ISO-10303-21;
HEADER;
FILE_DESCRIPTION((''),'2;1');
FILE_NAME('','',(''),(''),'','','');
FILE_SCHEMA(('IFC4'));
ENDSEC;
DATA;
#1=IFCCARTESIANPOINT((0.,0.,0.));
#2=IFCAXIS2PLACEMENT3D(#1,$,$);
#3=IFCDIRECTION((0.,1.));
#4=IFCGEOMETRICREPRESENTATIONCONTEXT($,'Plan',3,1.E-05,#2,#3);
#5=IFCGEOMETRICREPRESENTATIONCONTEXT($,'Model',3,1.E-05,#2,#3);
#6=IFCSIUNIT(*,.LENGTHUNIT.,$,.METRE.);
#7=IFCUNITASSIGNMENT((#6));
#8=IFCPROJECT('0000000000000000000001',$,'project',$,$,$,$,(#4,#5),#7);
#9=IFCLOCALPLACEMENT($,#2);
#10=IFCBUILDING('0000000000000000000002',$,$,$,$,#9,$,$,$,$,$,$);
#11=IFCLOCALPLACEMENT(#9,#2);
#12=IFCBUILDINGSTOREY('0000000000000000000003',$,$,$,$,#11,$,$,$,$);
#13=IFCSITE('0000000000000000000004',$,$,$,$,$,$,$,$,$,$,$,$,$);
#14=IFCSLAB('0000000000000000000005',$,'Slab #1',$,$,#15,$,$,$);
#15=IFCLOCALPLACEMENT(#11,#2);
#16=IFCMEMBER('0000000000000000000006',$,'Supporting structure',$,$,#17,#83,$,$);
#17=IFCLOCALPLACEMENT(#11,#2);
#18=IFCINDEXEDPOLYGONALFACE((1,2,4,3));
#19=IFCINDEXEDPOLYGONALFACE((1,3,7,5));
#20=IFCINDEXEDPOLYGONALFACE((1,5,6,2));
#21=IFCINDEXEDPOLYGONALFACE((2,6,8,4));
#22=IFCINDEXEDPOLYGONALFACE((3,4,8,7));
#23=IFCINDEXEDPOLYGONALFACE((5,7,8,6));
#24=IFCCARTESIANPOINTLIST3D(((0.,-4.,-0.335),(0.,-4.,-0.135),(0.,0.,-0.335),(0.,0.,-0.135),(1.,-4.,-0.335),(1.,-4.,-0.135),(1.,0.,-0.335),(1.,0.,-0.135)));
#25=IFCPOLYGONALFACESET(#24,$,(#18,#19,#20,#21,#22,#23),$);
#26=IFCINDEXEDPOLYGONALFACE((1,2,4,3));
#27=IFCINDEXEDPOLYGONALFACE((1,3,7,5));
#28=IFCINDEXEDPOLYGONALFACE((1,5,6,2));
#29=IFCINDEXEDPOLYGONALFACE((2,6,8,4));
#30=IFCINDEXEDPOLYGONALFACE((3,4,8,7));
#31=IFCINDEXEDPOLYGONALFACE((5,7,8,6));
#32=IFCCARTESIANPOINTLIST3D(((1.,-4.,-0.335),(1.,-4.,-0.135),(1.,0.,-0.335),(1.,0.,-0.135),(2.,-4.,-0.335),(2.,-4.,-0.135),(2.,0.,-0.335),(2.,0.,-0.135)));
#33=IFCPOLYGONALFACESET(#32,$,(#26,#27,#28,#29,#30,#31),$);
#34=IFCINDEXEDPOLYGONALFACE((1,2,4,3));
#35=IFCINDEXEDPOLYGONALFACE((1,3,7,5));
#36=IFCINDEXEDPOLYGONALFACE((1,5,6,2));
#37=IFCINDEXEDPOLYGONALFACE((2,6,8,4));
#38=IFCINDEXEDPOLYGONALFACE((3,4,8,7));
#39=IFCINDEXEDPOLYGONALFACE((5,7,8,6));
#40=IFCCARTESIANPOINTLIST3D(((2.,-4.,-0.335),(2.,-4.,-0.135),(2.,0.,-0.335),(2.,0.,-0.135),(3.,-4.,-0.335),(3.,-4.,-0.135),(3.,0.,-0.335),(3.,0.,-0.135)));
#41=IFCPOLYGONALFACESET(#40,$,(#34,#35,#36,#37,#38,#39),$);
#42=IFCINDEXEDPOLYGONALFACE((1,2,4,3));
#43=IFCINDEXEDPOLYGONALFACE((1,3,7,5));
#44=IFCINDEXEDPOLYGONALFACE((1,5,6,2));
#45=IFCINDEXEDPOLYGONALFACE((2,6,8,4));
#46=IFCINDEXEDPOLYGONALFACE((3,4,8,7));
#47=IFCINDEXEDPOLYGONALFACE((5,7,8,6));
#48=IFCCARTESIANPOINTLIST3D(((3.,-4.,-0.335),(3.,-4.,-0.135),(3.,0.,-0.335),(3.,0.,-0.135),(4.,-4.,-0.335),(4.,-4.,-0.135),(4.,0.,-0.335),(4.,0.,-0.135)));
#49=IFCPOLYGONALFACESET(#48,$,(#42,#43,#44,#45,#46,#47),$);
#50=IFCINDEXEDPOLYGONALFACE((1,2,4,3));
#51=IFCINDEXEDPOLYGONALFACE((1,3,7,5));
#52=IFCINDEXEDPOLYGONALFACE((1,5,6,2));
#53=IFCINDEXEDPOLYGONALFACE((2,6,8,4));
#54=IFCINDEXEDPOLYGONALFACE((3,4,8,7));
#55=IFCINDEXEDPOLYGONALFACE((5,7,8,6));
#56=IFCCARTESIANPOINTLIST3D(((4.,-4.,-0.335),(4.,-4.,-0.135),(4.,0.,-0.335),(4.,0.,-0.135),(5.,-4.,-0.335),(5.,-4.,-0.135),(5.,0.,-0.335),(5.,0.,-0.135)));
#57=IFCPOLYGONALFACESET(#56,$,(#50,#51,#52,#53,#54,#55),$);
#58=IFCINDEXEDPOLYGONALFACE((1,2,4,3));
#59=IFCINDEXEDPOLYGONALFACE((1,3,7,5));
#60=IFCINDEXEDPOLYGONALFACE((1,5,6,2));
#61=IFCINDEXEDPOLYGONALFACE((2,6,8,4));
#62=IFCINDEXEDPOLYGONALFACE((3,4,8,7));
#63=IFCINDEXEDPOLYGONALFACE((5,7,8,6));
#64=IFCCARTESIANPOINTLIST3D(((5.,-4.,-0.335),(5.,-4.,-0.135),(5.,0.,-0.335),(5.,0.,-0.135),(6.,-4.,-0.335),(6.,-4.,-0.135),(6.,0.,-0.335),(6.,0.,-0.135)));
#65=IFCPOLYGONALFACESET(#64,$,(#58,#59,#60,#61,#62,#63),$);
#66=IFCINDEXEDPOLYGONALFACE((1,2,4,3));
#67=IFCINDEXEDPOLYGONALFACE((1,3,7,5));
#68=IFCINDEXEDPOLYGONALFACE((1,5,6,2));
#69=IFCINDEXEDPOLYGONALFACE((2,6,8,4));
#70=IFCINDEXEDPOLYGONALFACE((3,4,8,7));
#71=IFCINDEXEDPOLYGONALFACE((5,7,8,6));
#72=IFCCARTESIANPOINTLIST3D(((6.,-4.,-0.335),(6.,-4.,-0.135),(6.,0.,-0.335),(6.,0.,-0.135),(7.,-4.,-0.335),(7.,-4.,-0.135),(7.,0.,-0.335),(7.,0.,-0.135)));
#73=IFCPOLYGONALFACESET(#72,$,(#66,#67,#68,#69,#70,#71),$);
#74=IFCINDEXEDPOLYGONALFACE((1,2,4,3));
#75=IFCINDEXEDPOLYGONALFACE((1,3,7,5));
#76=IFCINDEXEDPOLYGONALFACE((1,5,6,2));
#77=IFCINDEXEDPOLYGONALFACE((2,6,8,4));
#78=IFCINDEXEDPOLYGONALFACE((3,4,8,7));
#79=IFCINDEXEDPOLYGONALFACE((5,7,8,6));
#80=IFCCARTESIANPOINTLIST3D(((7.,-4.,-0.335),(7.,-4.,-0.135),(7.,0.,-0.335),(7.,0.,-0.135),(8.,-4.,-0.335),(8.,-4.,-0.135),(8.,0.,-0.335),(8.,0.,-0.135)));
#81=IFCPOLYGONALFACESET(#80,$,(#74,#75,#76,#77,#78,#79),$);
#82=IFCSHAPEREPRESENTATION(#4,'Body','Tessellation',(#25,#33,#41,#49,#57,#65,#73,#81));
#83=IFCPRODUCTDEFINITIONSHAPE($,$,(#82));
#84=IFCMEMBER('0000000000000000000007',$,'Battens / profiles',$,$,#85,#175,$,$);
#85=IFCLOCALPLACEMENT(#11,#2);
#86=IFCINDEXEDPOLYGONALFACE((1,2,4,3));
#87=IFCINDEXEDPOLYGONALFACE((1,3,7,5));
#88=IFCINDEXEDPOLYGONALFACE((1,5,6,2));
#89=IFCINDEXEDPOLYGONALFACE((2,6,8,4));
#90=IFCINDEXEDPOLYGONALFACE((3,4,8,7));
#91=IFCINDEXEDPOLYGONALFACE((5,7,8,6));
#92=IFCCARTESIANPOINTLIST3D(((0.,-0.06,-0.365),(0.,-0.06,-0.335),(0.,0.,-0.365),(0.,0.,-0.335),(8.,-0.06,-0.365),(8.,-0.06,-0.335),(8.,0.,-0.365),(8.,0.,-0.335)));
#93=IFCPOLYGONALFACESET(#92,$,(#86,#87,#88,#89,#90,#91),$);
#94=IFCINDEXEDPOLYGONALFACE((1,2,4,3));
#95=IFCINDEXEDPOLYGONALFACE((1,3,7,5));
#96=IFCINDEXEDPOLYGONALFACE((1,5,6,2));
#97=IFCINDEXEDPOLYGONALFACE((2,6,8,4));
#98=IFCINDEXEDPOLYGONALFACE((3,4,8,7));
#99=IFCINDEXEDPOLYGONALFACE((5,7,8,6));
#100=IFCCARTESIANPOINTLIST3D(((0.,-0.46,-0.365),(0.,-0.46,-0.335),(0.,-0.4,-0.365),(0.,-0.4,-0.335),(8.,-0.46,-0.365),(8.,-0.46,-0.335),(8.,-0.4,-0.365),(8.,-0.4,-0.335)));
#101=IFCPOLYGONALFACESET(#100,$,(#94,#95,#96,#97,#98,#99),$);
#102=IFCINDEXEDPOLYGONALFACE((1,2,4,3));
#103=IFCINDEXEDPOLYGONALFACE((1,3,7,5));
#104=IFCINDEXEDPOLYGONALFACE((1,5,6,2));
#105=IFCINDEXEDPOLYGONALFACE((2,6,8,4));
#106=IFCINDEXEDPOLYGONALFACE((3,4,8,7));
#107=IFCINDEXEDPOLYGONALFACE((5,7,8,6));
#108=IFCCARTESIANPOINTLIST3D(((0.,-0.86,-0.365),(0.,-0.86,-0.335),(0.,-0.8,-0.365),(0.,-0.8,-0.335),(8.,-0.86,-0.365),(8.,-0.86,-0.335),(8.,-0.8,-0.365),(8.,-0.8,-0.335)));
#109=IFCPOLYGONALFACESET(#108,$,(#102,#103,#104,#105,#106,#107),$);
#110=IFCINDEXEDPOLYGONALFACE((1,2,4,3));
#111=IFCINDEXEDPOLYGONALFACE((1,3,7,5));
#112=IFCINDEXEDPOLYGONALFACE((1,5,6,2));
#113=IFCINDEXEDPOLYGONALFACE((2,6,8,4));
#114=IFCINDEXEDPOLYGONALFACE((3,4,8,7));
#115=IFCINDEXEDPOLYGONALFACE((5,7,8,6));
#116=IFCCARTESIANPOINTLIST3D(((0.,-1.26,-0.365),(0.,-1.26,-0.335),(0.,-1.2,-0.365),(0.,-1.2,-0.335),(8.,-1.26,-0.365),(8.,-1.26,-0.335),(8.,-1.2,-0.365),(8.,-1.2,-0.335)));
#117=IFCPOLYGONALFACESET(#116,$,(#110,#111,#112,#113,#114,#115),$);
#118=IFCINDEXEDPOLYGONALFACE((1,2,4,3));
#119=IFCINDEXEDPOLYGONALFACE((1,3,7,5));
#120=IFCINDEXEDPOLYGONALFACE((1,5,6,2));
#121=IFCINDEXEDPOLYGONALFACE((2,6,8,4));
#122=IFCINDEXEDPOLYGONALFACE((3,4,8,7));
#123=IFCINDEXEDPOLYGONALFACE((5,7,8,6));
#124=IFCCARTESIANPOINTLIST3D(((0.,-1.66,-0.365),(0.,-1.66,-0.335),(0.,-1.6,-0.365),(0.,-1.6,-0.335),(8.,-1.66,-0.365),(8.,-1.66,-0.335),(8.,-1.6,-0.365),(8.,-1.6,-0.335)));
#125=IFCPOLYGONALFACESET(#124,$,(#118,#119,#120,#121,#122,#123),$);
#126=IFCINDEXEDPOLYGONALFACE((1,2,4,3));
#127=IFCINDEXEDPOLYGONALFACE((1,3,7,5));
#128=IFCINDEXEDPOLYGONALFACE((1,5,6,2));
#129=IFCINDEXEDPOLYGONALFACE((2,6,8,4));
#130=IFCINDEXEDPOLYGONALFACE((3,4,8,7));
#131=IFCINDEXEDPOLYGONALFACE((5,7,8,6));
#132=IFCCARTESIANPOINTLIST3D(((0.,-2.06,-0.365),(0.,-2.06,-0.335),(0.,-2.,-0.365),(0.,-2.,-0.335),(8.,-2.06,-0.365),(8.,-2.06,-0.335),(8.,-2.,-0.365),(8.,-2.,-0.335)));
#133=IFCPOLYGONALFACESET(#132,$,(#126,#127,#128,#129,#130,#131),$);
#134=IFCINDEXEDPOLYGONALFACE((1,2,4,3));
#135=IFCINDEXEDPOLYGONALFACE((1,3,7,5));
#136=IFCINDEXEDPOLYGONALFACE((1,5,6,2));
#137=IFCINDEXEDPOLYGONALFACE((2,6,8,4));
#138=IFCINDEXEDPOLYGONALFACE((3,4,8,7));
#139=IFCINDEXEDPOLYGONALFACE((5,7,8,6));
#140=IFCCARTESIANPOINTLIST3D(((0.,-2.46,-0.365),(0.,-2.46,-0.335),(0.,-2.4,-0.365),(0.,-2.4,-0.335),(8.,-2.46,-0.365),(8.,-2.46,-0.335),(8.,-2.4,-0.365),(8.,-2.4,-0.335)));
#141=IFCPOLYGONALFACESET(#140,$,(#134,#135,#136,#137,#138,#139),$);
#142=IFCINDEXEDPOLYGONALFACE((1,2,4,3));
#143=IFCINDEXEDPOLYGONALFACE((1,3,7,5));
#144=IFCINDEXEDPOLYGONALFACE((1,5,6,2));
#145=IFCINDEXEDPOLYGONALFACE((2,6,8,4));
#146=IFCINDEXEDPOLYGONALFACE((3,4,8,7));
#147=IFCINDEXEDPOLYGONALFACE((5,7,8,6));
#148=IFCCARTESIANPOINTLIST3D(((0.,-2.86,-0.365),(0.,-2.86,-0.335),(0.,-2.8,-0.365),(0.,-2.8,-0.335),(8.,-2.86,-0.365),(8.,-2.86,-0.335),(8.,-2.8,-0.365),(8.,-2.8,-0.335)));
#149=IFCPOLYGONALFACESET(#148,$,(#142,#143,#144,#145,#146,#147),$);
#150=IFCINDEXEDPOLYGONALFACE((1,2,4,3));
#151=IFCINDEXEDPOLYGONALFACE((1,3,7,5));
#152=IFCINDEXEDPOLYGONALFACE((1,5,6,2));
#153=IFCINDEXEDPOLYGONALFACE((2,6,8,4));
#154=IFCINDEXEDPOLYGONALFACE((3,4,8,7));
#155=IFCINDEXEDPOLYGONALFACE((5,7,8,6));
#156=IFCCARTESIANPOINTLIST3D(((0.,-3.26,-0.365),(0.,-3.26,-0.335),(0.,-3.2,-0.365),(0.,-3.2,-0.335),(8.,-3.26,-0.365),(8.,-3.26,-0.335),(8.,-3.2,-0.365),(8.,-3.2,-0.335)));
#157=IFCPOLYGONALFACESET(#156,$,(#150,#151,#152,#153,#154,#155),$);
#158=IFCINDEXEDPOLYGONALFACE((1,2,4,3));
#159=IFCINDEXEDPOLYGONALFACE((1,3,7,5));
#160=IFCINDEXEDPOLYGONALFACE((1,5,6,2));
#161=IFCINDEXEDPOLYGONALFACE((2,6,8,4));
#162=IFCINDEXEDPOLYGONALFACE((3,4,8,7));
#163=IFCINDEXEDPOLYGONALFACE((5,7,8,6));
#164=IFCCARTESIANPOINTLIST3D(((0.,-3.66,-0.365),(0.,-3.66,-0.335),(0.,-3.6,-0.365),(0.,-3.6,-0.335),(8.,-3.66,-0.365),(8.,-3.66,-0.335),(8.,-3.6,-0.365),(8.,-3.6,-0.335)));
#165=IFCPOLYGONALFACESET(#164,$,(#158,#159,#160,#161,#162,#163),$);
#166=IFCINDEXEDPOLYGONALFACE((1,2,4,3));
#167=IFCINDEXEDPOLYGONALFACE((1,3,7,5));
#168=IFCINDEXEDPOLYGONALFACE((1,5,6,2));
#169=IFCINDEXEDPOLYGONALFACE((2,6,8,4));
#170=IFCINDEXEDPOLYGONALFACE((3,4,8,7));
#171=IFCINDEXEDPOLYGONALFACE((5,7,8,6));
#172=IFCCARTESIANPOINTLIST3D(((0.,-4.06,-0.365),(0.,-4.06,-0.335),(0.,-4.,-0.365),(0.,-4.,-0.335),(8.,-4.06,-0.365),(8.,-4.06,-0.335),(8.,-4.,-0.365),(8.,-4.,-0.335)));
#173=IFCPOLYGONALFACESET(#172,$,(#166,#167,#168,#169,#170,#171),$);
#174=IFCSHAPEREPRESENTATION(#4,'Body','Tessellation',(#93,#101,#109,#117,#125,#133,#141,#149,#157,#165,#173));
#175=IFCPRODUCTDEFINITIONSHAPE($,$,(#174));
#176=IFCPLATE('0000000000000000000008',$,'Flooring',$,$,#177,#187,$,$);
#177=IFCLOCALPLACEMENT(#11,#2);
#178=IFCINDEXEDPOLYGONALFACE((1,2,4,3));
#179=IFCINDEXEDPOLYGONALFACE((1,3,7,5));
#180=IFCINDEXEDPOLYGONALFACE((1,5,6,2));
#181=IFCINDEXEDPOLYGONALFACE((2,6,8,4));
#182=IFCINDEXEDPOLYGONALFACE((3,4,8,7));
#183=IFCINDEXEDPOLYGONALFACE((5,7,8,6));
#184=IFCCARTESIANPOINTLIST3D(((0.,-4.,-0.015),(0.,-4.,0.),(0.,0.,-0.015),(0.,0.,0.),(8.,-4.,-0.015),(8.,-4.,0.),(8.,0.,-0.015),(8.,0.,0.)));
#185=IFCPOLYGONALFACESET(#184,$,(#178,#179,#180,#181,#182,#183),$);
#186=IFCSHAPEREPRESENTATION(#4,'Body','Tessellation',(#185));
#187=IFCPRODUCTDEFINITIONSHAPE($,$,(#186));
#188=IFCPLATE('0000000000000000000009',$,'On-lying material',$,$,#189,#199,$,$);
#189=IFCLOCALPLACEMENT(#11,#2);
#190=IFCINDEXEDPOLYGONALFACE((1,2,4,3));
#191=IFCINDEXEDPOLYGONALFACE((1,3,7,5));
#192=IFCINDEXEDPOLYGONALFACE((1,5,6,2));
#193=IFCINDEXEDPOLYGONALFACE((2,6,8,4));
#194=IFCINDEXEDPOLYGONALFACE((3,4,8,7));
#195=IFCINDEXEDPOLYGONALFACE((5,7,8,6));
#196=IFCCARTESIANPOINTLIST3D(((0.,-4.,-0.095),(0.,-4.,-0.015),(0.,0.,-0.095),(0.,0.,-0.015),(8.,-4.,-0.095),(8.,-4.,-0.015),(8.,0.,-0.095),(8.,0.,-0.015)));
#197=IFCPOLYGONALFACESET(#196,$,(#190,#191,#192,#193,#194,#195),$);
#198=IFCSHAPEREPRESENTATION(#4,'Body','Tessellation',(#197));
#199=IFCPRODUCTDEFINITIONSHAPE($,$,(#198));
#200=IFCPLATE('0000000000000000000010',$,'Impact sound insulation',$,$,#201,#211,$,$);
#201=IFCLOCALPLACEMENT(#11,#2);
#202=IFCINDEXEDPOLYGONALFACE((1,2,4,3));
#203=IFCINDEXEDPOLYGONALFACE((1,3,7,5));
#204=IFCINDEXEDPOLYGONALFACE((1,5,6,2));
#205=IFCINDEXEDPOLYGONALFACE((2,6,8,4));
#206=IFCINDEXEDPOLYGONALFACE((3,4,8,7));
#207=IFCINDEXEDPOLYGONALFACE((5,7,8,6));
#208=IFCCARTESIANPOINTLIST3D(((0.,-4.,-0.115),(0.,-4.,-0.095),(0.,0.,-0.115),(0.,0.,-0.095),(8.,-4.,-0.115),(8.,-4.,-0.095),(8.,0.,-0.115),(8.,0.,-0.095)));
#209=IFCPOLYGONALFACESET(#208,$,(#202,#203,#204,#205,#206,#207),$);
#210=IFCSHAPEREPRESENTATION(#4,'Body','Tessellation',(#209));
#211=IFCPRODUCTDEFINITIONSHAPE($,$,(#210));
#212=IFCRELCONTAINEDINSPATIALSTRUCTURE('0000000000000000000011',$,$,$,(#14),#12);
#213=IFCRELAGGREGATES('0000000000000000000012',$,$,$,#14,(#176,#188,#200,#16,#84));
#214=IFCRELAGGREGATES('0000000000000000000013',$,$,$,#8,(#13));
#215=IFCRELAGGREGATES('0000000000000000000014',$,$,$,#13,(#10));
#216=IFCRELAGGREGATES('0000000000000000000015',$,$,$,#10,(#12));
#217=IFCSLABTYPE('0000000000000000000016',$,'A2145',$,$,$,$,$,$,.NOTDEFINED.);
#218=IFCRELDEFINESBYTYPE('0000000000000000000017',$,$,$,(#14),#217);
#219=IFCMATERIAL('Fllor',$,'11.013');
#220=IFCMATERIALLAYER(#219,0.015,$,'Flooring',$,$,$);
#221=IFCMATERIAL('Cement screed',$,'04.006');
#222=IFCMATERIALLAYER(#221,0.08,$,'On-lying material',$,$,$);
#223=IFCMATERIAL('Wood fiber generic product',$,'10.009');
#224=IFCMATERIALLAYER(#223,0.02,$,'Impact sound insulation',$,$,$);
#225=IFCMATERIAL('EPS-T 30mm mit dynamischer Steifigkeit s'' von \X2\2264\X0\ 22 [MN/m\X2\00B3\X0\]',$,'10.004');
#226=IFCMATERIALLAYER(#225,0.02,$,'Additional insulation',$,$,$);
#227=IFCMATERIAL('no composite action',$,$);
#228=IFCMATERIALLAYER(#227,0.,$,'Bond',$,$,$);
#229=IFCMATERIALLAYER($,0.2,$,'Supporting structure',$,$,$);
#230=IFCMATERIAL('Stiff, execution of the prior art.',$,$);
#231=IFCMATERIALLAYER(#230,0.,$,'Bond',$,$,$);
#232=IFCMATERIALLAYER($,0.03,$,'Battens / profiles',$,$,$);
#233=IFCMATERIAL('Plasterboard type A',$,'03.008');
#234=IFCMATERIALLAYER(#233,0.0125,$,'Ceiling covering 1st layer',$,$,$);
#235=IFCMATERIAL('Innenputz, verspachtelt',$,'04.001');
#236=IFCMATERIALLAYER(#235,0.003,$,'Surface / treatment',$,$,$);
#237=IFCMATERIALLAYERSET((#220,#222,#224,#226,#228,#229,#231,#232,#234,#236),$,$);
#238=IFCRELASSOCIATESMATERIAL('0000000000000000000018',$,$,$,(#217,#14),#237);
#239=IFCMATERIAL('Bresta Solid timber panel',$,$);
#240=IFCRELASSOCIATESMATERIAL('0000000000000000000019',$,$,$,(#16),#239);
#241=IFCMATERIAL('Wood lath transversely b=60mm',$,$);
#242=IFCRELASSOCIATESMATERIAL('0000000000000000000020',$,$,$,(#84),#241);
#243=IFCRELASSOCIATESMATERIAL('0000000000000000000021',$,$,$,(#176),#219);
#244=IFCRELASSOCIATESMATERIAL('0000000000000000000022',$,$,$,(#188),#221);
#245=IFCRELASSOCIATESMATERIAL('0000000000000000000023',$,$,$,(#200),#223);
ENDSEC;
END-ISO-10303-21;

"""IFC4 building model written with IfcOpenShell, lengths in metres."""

from ifc_helpers import new_model, si_unit, direction, frame, frame_2d, origin, origin_with_axes, place, context, project, spatial, rectangle, extrude, material, layer, layer_set, type_object, element, aggregate, save


model = new_model("IFC4")

# Units and contexts
plan_context = context("Plan", 3, precision=1e-05, world=origin(), true_north=direction((0.0, 1.0)))
model_context = context("Model", 3, precision=1e-05, world=origin(), true_north=direction((0.0, 1.0)))
ifc_project = project(units=[si_unit("LENGTHUNIT", "METRE")], contexts=[plan_context, model_context])

# Site, building, storey
site = spatial("IfcSite", under=ifc_project)
building_placement = place(None, origin())
building = spatial("IfcBuilding", under=site, at=building_placement)
storey_placement = place(building_placement, origin())
storey = spatial("IfcBuildingStorey", under=building, at=storey_placement)

# Slab, members, plates
ifc_material_1 = material(Name="Fllor", Category="11.013")
ifc_layer_1 = layer(ifc_material_1, 0.015, Name="Flooring")
ifc_material_2 = material(Name="Cement screed", Category="04.006")
ifc_layer_2 = layer(ifc_material_2, 0.08, Name="On-lying material")
ifc_material_3 = material(Name="Wood fiber generic product", Category="10.009")
ifc_layer_3 = layer(ifc_material_3, 0.02, Name="Impact sound insulation")
ifc_material_4 = material(Name="EPS-T 30mm mit dynamischer Steifigkeit s' von ≤ 22 [MN/m³]", Category="10.004")
ifc_layer_4 = layer(ifc_material_4, 0.02, Name="Additional insulation")
ifc_material_5 = material(Name="no composite action")
ifc_layer_5 = layer(ifc_material_5, 0.0, Name="Bond")
ifc_layer_6 = layer(None, 0.2, Name="Supporting structure")
ifc_material_6 = material(Name="Stiff, execution of the prior art.")
ifc_layer_7 = layer(ifc_material_6, 0.0, Name="Bond")
ifc_layer_8 = layer(None, 0.03, Name="Battens / profiles")
ifc_material_7 = material(Name="Plasterboard type A", Category="03.008")
ifc_layer_9 = layer(ifc_material_7, 0.0125, Name="Ceiling covering 1st layer")
ifc_material_8 = material(Name="Innenputz, verspachtelt", Category="04.001")
ifc_layer_10 = layer(ifc_material_8, 0.003, Name="Surface / treatment")
ifc_layer_set = layer_set([ifc_layer_1, ifc_layer_2, ifc_layer_3, ifc_layer_4, ifc_layer_5, ifc_layer_6, ifc_layer_7, ifc_layer_8, ifc_layer_9, ifc_layer_10])
slab_type = type_object("IfcSlabType", Name="A2145", PredefinedType="NOTDEFINED", material=ifc_layer_set)
slab_placement = place(None, frame((0.0, 0.0, 0.0), z_axis=(0.0, 0.0, -1.0), x_axis=(1.0, 0.0, 0.0)))
slab = element("IfcSlab", 1, at=slab_placement, inside=storey, type_object=slab_type, material=ifc_layer_set, Name="Slab #1")
ifc_material_9 = material(Name="Bresta Solid timber panel")
member_1_placement = place(slab_placement, origin())
member_1 = element("IfcMember", 2, at=member_1_placement, material=ifc_material_9, Name="Supporting structure", context=plan_context, shape_type="SweptSolid", body=[
    extrude(rectangle(XDim=1.0, YDim=0.2, at=frame_2d((0.5, 0.1), x_axis=(1.0, 0.0))), frame((0.0, 4.0, 0.135), z_axis=(0.0, -1.0, 0.0), x_axis=(1.0, 0.0, 0.0)), (0.0, 0.0, 1.0), 4.0),
    extrude(rectangle(XDim=1.0, YDim=0.2, at=frame_2d((0.5, 0.1), x_axis=(1.0, 0.0))), frame((1.0, 4.0, 0.135), z_axis=(0.0, -1.0, 0.0), x_axis=(1.0, 0.0, 0.0)), (0.0, 0.0, 1.0), 4.0),
    extrude(rectangle(XDim=1.0, YDim=0.2, at=frame_2d((0.5, 0.1), x_axis=(1.0, 0.0))), frame((2.0, 4.0, 0.135), z_axis=(0.0, -1.0, 0.0), x_axis=(1.0, 0.0, 0.0)), (0.0, 0.0, 1.0), 4.0),
    extrude(rectangle(XDim=1.0, YDim=0.2, at=frame_2d((0.5, 0.1), x_axis=(1.0, 0.0))), frame((3.0, 4.0, 0.135), z_axis=(0.0, -1.0, 0.0), x_axis=(1.0, 0.0, 0.0)), (0.0, 0.0, 1.0), 4.0),
    extrude(rectangle(XDim=1.0, YDim=0.2, at=frame_2d((0.5, 0.1), x_axis=(1.0, 0.0))), frame((4.0, 4.0, 0.135), z_axis=(0.0, -1.0, 0.0), x_axis=(1.0, 0.0, 0.0)), (0.0, 0.0, 1.0), 4.0),
    extrude(rectangle(XDim=1.0, YDim=0.2, at=frame_2d((0.5, 0.1), x_axis=(1.0, 0.0))), frame((5.0, 4.0, 0.135), z_axis=(0.0, -1.0, 0.0), x_axis=(1.0, 0.0, 0.0)), (0.0, 0.0, 1.0), 4.0),
    extrude(rectangle(XDim=1.0, YDim=0.2, at=frame_2d((0.5, 0.1), x_axis=(1.0, 0.0))), frame((6.0, 4.0, 0.135), z_axis=(0.0, -1.0, 0.0), x_axis=(1.0, 0.0, 0.0)), (0.0, 0.0, 1.0), 4.0),
    extrude(rectangle(XDim=1.0, YDim=0.2, at=frame_2d((0.5, 0.1), x_axis=(1.0, 0.0))), frame((7.0, 4.0, 0.135), z_axis=(0.0, -1.0, 0.0), x_axis=(1.0, 0.0, 0.0)), (0.0, 0.0, 1.0), 4.0),
])
ifc_material_10 = material(Name="Wood lath transversely b=60mm")
member_2_placement = place(slab_placement, origin())
member_2 = element("IfcMember", 3, at=member_2_placement, material=ifc_material_10, Name="Battens / profiles", context=plan_context, shape_type="SweptSolid", body=[
    extrude(rectangle(XDim=0.06, YDim=0.03, at=frame_2d((0.03, 0.015), x_axis=(1.0, 0.0))), frame((0.0, 0.0, 0.335), z_axis=(1.0, 0.0, 0.0), x_axis=(0.0, 1.0, 0.0)), (0.0, 0.0, 1.0), 8.0),
    extrude(rectangle(XDim=0.06, YDim=0.03, at=frame_2d((0.03, 0.015), x_axis=(1.0, 0.0))), frame((0.0, 0.4, 0.335), z_axis=(1.0, 0.0, 0.0), x_axis=(0.0, 1.0, 0.0)), (0.0, 0.0, 1.0), 8.0),
    extrude(rectangle(XDim=0.06, YDim=0.03, at=frame_2d((0.03, 0.015), x_axis=(1.0, 0.0))), frame((0.0, 0.8, 0.335), z_axis=(1.0, 0.0, 0.0), x_axis=(0.0, 1.0, 0.0)), (0.0, 0.0, 1.0), 8.0),
    extrude(rectangle(XDim=0.06, YDim=0.03, at=frame_2d((0.03, 0.015), x_axis=(1.0, 0.0))), frame((0.0, 1.2, 0.335), z_axis=(1.0, 0.0, 0.0), x_axis=(0.0, 1.0, 0.0)), (0.0, 0.0, 1.0), 8.0),
    extrude(rectangle(XDim=0.06, YDim=0.03, at=frame_2d((0.03, 0.015), x_axis=(1.0, 0.0))), frame((0.0, 1.6, 0.335), z_axis=(1.0, 0.0, 0.0), x_axis=(0.0, 1.0, 0.0)), (0.0, 0.0, 1.0), 8.0),
    extrude(rectangle(XDim=0.06, YDim=0.03, at=frame_2d((0.03, 0.015), x_axis=(1.0, 0.0))), frame((0.0, 2.0, 0.335), z_axis=(1.0, 0.0, 0.0), x_axis=(0.0, 1.0, 0.0)), (0.0, 0.0, 1.0), 8.0),
    extrude(rectangle(XDim=0.06, YDim=0.03, at=frame_2d((0.03, 0.015), x_axis=(1.0, 0.0))), frame((0.0, 2.4, 0.335), z_axis=(1.0, 0.0, 0.0), x_axis=(0.0, 1.0, 0.0)), (0.0, 0.0, 1.0), 8.0),
    extrude(rectangle(XDim=0.06, YDim=0.03, at=frame_2d((0.03, 0.015), x_axis=(1.0, 0.0))), frame((0.0, 2.8, 0.335), z_axis=(1.0, 0.0, 0.0), x_axis=(0.0, 1.0, 0.0)), (0.0, 0.0, 1.0), 8.0),
    extrude(rectangle(XDim=0.06, YDim=0.03, at=frame_2d((0.03, 0.015), x_axis=(1.0, 0.0))), frame((0.0, 3.2, 0.335), z_axis=(1.0, 0.0, 0.0), x_axis=(0.0, 1.0, 0.0)), (0.0, 0.0, 1.0), 8.0),
    extrude(rectangle(XDim=0.06, YDim=0.03, at=frame_2d((0.03, 0.015), x_axis=(1.0, 0.0))), frame((0.0, 3.6, 0.335), z_axis=(1.0, 0.0, 0.0), x_axis=(0.0, 1.0, 0.0)), (0.0, 0.0, 1.0), 8.0),
    extrude(rectangle(XDim=0.06, YDim=0.03, at=frame_2d((0.03, 0.015), x_axis=(1.0, 0.0))), frame((0.0, 4.0, 0.335), z_axis=(1.0, 0.0, 0.0), x_axis=(0.0, 1.0, 0.0)), (0.0, 0.0, 1.0), 8.0),
])
plate_1_placement = place(slab_placement, origin())
plate_1 = element("IfcPlate", 4, at=plate_1_placement, material=ifc_material_1, Name="Flooring", context=plan_context, shape_type="SweptSolid", body=[
    extrude(rectangle(XDim=8.0, YDim=4.0, at=frame_2d((4.0, 2.0), x_axis=(1.0, 0.0))), origin_with_axes(), (0.0, 0.0, 1.0), 0.015),
])
plate_2_placement = place(slab_placement, origin())
plate_2 = element("IfcPlate", 5, at=plate_2_placement, material=ifc_material_2, Name="On-lying material", context=plan_context, shape_type="SweptSolid", body=[
    extrude(rectangle(XDim=8.0, YDim=4.0, at=frame_2d((4.0, 2.0), x_axis=(1.0, 0.0))), frame((0.0, 0.0, 0.015), z_axis=(0.0, 0.0, 1.0), x_axis=(1.0, 0.0, 0.0)), (0.0, 0.0, 1.0), 0.08),
])
plate_3_placement = place(slab_placement, origin())
plate_3 = element("IfcPlate", 6, at=plate_3_placement, material=ifc_material_3, Name="Impact sound insulation", context=plan_context, shape_type="SweptSolid", body=[
    extrude(rectangle(XDim=8.0, YDim=4.0, at=frame_2d((4.0, 2.0), x_axis=(1.0, 0.0))), frame((0.0, 0.0, 0.095), z_axis=(0.0, 0.0, 1.0), x_axis=(1.0, 0.0, 0.0)), (0.0, 0.0, 1.0), 0.02),
])
aggregate(slab, [plate_1, plate_2, plate_3, member_1, member_2])

save(model, "model.ifc")
